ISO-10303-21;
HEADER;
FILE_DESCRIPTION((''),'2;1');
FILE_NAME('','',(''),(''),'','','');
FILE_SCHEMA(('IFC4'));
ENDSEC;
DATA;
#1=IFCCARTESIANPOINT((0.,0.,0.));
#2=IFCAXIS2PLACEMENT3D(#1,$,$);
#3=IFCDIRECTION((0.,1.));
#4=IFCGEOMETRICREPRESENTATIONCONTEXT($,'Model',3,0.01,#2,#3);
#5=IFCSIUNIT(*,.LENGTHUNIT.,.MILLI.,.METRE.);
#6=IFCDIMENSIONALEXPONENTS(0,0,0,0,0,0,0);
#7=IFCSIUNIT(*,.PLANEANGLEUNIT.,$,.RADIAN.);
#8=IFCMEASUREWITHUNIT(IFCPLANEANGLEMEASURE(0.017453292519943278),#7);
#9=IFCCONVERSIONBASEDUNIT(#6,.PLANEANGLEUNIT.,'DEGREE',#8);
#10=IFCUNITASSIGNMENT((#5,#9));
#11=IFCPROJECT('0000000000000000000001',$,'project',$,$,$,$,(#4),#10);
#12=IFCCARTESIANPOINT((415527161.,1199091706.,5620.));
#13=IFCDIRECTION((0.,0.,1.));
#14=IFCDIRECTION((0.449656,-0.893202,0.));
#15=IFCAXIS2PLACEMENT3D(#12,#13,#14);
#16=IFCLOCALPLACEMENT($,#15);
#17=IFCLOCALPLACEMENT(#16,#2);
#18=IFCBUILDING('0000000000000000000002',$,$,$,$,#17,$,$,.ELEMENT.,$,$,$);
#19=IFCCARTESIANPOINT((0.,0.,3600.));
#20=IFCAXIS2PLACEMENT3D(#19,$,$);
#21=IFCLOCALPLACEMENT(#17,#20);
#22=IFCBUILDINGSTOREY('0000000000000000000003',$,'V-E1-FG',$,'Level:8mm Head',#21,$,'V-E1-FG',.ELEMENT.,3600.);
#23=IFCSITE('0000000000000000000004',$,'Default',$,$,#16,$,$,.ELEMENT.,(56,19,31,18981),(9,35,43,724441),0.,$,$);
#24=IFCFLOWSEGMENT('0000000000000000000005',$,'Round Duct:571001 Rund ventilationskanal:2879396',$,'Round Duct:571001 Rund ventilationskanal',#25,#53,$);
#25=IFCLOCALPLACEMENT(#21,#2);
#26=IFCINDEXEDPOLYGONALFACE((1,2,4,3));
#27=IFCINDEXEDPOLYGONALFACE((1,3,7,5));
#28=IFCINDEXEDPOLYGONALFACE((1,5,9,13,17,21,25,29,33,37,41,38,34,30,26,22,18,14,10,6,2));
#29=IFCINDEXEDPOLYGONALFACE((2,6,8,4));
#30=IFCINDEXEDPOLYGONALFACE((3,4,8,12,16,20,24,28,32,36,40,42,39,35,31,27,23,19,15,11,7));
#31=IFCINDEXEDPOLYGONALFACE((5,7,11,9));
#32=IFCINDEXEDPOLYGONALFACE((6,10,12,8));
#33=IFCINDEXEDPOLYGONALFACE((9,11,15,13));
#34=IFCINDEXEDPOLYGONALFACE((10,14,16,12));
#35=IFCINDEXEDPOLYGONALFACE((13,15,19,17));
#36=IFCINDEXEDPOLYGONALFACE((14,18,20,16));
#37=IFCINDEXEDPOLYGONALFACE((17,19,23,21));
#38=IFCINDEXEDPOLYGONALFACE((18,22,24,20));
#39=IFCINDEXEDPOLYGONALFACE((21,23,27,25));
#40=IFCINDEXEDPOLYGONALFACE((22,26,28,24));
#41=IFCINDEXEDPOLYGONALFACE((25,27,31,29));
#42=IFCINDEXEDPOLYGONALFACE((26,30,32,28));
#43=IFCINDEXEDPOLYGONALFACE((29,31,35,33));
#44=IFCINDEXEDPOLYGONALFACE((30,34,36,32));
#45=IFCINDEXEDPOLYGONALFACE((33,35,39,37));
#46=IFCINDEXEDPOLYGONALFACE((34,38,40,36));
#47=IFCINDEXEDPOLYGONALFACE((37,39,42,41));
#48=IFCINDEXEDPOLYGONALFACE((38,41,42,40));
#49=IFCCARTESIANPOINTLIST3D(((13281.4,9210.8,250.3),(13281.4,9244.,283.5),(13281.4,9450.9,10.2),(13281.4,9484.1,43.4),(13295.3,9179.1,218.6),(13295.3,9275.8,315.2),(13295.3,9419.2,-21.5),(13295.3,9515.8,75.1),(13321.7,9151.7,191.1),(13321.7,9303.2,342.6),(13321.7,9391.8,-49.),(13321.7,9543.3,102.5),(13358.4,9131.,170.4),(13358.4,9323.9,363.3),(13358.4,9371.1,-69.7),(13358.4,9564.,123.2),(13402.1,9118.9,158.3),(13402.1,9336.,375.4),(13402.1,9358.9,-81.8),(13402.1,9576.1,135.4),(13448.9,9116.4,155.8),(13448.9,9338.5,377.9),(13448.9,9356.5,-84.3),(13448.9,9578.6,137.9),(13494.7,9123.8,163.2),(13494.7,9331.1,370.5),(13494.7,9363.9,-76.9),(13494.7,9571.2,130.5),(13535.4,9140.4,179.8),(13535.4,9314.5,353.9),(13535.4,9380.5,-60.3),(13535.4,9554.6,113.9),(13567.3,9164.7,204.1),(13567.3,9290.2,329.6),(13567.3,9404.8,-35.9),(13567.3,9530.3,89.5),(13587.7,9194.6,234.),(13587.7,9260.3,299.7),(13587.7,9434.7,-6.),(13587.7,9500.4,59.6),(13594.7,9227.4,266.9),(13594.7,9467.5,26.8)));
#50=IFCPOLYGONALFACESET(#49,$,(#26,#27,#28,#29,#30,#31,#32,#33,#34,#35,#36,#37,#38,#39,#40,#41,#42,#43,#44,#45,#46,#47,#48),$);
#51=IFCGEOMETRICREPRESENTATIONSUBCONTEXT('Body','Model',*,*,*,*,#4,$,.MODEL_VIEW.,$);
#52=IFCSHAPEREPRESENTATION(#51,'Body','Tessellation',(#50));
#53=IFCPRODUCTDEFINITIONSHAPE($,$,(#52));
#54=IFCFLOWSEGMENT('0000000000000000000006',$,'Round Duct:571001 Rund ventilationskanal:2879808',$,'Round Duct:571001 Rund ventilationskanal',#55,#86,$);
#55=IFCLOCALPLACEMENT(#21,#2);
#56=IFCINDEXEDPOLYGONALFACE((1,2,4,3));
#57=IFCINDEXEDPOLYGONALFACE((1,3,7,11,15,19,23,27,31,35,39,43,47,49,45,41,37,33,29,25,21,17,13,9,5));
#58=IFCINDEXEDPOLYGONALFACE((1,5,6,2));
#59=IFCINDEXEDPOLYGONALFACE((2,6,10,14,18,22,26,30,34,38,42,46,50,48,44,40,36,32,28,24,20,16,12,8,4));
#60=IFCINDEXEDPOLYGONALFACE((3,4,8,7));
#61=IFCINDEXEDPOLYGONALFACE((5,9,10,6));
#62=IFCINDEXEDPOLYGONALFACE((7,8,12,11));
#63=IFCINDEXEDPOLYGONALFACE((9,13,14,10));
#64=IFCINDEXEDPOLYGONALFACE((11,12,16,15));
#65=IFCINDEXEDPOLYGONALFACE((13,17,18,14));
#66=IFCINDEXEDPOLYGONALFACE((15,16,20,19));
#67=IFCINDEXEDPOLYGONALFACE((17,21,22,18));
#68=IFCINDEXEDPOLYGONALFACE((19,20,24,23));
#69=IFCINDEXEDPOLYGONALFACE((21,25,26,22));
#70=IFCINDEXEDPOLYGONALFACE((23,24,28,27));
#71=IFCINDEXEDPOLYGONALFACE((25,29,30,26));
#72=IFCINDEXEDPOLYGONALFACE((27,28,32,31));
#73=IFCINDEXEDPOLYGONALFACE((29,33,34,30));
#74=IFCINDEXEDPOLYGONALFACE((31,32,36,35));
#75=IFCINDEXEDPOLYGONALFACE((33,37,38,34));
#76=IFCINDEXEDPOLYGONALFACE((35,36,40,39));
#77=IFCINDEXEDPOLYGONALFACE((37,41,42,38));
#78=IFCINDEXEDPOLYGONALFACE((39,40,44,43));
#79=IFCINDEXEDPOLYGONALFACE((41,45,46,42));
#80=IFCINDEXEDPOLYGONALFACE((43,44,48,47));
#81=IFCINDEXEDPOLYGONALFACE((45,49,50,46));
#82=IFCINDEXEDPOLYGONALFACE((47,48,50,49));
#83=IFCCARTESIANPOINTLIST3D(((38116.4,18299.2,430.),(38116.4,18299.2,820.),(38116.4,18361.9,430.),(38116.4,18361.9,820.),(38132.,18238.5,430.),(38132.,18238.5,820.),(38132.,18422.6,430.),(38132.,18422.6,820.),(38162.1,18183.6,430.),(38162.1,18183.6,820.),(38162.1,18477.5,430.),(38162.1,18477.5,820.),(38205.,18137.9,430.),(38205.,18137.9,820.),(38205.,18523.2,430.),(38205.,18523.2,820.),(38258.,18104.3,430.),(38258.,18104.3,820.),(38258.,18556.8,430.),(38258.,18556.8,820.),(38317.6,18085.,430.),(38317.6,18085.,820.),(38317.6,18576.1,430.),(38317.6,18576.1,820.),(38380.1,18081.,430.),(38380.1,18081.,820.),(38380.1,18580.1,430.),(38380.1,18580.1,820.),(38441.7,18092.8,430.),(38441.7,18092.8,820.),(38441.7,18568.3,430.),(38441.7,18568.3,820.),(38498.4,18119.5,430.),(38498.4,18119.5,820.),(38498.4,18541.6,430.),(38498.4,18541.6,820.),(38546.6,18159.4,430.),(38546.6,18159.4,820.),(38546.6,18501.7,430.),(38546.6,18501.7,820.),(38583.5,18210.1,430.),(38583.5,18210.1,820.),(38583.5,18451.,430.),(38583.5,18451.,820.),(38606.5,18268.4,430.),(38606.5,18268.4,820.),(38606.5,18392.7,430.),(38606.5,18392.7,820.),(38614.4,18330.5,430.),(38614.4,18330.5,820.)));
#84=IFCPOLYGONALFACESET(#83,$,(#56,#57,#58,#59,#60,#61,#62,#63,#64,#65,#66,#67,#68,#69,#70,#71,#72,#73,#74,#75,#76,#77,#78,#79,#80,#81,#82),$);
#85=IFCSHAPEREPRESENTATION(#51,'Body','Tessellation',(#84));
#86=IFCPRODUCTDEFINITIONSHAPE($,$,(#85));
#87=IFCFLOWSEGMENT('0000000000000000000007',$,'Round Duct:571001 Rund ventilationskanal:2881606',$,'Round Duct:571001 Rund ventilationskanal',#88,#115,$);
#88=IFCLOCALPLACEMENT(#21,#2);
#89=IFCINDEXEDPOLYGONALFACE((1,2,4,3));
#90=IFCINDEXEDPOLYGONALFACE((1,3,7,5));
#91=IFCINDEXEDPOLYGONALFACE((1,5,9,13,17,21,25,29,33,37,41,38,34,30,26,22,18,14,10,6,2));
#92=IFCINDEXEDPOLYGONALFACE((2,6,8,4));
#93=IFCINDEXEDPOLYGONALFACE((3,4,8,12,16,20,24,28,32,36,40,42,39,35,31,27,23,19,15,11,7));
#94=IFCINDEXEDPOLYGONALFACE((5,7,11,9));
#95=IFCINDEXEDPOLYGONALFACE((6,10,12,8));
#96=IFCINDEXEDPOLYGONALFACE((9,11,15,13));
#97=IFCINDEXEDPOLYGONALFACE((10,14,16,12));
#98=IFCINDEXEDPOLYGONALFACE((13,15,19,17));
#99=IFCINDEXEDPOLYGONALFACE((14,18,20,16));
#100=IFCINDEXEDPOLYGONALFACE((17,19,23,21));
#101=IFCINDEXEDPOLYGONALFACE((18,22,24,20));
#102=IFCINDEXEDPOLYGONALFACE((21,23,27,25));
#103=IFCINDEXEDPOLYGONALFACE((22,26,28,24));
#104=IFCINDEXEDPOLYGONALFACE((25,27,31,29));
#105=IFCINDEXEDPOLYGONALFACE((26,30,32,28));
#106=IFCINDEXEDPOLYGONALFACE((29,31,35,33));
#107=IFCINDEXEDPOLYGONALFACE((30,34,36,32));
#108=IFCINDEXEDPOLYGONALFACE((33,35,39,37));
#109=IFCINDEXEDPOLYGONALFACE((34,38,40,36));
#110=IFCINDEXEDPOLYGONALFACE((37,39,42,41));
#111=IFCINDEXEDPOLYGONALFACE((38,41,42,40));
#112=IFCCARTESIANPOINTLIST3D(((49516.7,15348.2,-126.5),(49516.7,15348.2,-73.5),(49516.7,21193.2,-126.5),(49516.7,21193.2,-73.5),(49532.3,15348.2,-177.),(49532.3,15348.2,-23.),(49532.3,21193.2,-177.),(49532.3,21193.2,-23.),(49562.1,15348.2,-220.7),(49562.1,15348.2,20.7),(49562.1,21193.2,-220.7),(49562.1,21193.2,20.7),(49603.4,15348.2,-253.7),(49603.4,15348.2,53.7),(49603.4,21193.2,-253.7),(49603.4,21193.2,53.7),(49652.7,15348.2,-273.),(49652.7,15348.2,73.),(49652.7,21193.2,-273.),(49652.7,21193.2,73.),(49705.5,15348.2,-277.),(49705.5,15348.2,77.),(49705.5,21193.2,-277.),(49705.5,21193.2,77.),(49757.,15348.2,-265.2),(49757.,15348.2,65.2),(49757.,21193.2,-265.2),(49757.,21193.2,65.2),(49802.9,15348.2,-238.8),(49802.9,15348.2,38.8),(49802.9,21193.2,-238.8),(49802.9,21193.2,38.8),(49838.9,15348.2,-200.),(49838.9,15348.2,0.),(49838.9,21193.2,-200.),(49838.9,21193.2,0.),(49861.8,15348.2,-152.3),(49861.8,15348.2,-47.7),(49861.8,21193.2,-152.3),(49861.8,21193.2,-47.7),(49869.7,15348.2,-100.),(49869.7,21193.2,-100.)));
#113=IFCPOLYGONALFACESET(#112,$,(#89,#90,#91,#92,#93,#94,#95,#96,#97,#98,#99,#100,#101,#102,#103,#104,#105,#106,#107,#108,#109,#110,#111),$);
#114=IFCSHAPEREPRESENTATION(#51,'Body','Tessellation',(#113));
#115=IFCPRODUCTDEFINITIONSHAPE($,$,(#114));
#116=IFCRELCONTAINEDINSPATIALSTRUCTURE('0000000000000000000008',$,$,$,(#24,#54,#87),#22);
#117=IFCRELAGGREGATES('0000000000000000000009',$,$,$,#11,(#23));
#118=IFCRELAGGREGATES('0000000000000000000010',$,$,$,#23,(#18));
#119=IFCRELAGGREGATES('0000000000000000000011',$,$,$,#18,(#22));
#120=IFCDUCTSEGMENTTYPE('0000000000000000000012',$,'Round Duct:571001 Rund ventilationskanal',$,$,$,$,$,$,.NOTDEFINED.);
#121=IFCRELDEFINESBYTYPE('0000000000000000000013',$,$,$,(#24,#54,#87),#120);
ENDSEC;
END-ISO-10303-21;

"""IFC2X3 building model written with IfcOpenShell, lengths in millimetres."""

from ifc_helpers import new_model, entity, si_unit, converted_unit, direction, frame, frame_2d, origin, origin_2d_with_axis, place, context, subcontext, project, spatial, circle, extrude, type_object, element, save


model = new_model("IFC2X3")

# Units and contexts
model_context = context("Model", 3, precision=0.01, world=origin(), true_north=direction((0.0, 1.0)))
body_context = subcontext(model_context, "Body", "Model", "MODEL_VIEW")
ifc_project = project(units=[si_unit("LENGTHUNIT", "METRE", prefix="MILLI"), converted_unit("PLANEANGLEUNIT", "DEGREE", entity("IfcPlaneAngleMeasure", 0.017453292519943278), si_unit("PLANEANGLEUNIT", "RADIAN"), dimensions=[0, 0, 0, 0, 0, 0, 0])], contexts=[model_context])

# Site, building, storey
site_placement = place(None, frame((415527161.0, 1199091706.0, 5620.0), z_axis=(0.0, 0.0, 1.0), x_axis=(0.449656, -0.893202, 0.0)))
site = spatial("IfcSite", under=ifc_project, at=site_placement, Name="Default", CompositionType="ELEMENT", RefLatitude=(56, 19, 31, 18981), RefLongitude=(9, 35, 43, 724441), RefElevation=0.0)
building_placement = place(site_placement, origin())
building = spatial("IfcBuilding", under=site, at=building_placement, CompositionType="ELEMENT")
storey_placement = place(building_placement, frame((0.0, 0.0, 3600.0)))
storey = spatial("IfcBuildingStorey", under=building, at=storey_placement, Name="V-E1-FG", ObjectType="Level:8mm Head", LongName="V-E1-FG", CompositionType="ELEMENT", Elevation=3600.0)

# Flow segments
duct_segment_type = type_object("IfcDuctSegmentType", Name="Round Duct:571001 Rund ventilationskanal", PredefinedType="NOTDEFINED")
flow_segment_1_placement = place(storey_placement, origin())
element("IfcFlowSegment", 1, at=flow_segment_1_placement, inside=storey, type_object=duct_segment_type, Name="Round Duct:571001 Rund ventilationskanal:2879396", ObjectType="Round Duct:571001 Rund ventilationskanal", context=body_context, shape_type="SweptSolid", body=[
    extrude(circle(Radius=157.5, at=frame_2d((0.0, 0.0), x_axis=(1.0, 0.0))), frame((13437.2, 9227.4, 266.9), z_axis=(0.0, 0.707107, -0.707107), x_axis=(1.0, 0.0, 0.0)), (0.0, 0.0, 1.0), 339.5),
])
flow_segment_2_placement = place(storey_placement, origin())
element("IfcFlowSegment", 2, at=flow_segment_2_placement, inside=storey, type_object=duct_segment_type, Name="Round Duct:571001 Rund ventilationskanal:2879808", ObjectType="Round Duct:571001 Rund ventilationskanal", context=body_context, shape_type="SweptSolid", body=[
    extrude(circle(Radius=250.0, at=origin_2d_with_axis()), frame((38364.4, 18330.5, 430.0)), (0.0, 0.0, 1.0), 390.0),
])
flow_segment_3_placement = place(storey_placement, origin())
element("IfcFlowSegment", 3, at=flow_segment_3_placement, inside=storey, type_object=duct_segment_type, Name="Round Duct:571001 Rund ventilationskanal:2881606", ObjectType="Round Duct:571001 Rund ventilationskanal", context=body_context, shape_type="SweptSolid", body=[
    extrude(circle(Radius=177.5, at=frame_2d((0.0, 0.0), x_axis=(1.0, 0.0))), frame((49692.2, 15348.2, -100.0), z_axis=(0.0, 1.0, 0.0), x_axis=(1.0, 0.0, 0.0)), (0.0, 0.0, 1.0), 5845.0),
])

save(model, "model.ifc")
